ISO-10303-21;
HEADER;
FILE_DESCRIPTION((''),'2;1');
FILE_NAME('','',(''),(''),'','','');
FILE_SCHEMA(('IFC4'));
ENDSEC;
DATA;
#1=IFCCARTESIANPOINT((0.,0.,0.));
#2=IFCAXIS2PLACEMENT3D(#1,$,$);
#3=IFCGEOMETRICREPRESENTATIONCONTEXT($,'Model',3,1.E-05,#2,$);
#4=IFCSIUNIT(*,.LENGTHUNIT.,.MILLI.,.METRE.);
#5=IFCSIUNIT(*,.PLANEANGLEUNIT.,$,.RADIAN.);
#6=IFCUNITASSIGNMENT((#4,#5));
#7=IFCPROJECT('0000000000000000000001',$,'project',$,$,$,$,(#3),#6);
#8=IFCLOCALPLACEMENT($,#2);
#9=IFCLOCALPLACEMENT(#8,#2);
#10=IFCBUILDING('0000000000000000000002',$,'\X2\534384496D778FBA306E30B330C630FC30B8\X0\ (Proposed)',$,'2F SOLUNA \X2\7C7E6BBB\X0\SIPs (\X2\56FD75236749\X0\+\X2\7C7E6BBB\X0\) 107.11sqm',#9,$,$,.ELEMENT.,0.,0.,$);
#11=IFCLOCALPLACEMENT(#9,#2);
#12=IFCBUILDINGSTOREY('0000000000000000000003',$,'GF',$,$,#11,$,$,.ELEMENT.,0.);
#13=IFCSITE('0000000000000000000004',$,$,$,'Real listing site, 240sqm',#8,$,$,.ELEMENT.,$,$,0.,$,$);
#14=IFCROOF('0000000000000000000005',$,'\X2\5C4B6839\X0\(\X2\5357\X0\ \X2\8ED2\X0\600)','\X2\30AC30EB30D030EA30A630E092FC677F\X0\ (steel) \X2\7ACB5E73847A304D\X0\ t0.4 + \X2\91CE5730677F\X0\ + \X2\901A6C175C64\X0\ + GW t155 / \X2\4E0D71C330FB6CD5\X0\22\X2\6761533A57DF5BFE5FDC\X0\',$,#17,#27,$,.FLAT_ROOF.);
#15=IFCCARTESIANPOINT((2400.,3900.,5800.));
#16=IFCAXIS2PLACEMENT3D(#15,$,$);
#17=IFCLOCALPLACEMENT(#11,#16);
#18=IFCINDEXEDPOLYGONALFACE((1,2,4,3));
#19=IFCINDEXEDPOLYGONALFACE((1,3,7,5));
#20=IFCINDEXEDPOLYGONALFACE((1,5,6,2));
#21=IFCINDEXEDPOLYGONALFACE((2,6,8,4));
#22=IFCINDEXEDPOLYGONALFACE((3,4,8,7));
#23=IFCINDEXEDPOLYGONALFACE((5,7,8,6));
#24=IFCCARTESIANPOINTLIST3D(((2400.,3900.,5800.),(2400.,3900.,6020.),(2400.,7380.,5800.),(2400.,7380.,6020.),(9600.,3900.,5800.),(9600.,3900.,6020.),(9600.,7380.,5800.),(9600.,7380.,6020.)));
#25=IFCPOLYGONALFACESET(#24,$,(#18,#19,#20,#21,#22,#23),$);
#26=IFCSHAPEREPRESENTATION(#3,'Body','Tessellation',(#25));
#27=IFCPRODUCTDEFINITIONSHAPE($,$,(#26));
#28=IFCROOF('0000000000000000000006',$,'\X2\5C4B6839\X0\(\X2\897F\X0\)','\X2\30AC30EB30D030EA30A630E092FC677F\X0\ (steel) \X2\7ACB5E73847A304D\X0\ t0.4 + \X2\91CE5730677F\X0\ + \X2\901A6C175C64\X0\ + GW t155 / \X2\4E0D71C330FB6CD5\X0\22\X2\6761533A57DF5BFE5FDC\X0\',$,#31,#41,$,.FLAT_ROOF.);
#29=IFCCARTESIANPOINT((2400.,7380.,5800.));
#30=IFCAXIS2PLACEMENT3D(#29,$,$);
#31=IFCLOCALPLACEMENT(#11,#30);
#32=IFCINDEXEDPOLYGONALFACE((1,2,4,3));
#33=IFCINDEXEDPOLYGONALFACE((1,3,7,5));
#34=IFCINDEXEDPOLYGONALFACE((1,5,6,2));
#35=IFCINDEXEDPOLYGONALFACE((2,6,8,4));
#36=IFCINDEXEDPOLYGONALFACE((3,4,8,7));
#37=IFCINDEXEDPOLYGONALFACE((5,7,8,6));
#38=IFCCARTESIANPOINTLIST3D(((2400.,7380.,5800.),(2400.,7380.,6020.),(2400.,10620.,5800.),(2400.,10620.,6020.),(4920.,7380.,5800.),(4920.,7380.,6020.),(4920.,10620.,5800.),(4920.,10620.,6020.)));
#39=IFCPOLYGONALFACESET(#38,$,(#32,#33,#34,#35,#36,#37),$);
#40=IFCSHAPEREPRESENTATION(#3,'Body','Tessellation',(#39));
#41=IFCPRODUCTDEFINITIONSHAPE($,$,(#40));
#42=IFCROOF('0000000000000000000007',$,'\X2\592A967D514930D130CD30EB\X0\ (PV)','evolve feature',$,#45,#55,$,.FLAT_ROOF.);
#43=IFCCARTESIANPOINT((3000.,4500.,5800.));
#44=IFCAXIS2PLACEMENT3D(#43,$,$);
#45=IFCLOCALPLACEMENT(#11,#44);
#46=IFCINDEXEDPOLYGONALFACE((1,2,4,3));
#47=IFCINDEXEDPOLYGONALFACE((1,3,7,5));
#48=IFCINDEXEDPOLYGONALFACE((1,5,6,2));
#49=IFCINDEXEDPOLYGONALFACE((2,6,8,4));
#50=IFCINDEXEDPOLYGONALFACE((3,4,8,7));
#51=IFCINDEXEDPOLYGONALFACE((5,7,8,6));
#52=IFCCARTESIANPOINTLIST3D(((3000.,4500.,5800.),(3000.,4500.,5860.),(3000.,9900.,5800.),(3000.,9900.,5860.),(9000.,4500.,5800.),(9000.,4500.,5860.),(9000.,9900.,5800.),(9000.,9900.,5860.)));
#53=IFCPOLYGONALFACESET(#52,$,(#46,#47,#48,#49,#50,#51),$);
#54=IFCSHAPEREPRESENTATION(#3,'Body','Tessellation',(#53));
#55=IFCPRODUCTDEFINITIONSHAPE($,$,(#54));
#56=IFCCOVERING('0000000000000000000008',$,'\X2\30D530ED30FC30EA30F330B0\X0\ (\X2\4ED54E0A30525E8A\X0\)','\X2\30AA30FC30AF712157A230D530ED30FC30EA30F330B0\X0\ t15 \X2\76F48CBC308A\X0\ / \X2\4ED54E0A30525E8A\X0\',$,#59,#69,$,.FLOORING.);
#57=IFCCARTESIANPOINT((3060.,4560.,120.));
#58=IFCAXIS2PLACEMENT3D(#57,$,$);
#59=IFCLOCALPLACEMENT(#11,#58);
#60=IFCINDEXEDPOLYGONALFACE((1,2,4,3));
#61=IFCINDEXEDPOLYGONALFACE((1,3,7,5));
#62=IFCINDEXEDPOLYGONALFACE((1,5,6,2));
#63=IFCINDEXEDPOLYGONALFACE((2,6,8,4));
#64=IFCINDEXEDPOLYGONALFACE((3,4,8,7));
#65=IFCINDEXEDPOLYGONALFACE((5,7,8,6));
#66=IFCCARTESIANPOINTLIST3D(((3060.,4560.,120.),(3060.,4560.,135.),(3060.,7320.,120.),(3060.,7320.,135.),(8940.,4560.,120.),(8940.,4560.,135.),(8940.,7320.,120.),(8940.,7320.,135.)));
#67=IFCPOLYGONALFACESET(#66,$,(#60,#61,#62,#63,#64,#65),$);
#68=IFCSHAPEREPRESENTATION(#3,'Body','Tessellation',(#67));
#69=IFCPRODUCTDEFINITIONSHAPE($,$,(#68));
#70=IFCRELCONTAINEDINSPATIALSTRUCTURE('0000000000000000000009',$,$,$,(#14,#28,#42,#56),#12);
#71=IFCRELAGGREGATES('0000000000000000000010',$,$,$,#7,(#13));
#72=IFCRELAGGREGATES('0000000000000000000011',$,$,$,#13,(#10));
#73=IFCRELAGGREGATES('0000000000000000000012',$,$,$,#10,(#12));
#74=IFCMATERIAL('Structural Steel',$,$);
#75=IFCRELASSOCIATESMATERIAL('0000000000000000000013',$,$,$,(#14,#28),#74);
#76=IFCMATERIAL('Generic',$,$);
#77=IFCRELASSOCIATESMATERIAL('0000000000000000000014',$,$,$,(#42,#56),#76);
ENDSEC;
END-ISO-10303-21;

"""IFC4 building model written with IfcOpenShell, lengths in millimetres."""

from ifc_helpers import new_model, si_unit, frame, frame_2d, origin, place, context, project, spatial, rectangle, extrude, material, element, save


model = new_model("IFC4")

# Units and contexts
model_context = context("Model", 3, precision=1e-05, world=origin())
ifc_project = project(units=[si_unit("LENGTHUNIT", "METRE", prefix="MILLI"), si_unit("PLANEANGLEUNIT", "RADIAN")], contexts=[model_context])

# Site, building, storey
site_placement = place(None, origin())
site = spatial("IfcSite", under=ifc_project, at=site_placement, ObjectType="Real listing site, 240sqm", CompositionType="ELEMENT", RefElevation=0.0)
building_placement = place(site_placement, origin())
building = spatial("IfcBuilding", under=site, at=building_placement, Name="千葉海辺のコテージ (Proposed)", ObjectType="2F SOLUNA 籾殻SIPs (国産杉+籾殻) 107.11sqm", CompositionType="ELEMENT", ElevationOfRefHeight=0.0, ElevationOfTerrain=0.0)
storey_placement = place(building_placement, origin())
storey = spatial("IfcBuildingStorey", under=building, at=storey_placement, Name="GF", CompositionType="ELEMENT", Elevation=0.0)

# Shared definitions
ifc_material_1 = material(Name="Generic")

# Roofs
ifc_material_2 = material(Name="Structural Steel")
roof_1_placement = place(storey_placement, frame((2400.0, 3900.0, 5800.0)))
element("IfcRoof", 1, at=roof_1_placement, inside=storey, material=ifc_material_2, Name="屋根(南 軒600)", Description="ガルバリウム鋼板 (steel) 立平葺き t0.4 + 野地板 + 通気層 + GW t155 / 不燃・法22条区域対応", PredefinedType="FLAT_ROOF", context=model_context, shape_type="SweptSolid", body=[
    extrude(rectangle(XDim=7200.0, YDim=3480.0, at=frame_2d((3600.0, 1740.0))), frame((2400.0, 3900.0, 5800.0)), (0.0, 0.0, 1.0), 220.0),
])
roof_2_placement = place(storey_placement, frame((2400.0, 7380.0, 5800.0)))
element("IfcRoof", 2, at=roof_2_placement, inside=storey, material=ifc_material_2, Name="屋根(西)", Description="ガルバリウム鋼板 (steel) 立平葺き t0.4 + 野地板 + 通気層 + GW t155 / 不燃・法22条区域対応", PredefinedType="FLAT_ROOF", context=model_context, shape_type="SweptSolid", body=[
    extrude(rectangle(XDim=2520.0, YDim=3240.0, at=frame_2d((1260.0, 1620.0))), frame((2400.0, 7380.0, 5800.0)), (0.0, 0.0, 1.0), 220.0),
])
roof_3_placement = place(storey_placement, frame((3000.0, 4500.0, 5800.0)))
element("IfcRoof", 3, at=roof_3_placement, inside=storey, material=ifc_material_1, Name="太陽光パネル (PV)", Description="evolve feature", PredefinedType="FLAT_ROOF", context=model_context, shape_type="SweptSolid", body=[
    extrude(rectangle(XDim=6000.0, YDim=5400.0, at=frame_2d((3000.0, 2700.0))), frame((3000.0, 4500.0, 5800.0)), (0.0, 0.0, 1.0), 60.0),
])

# Covering
covering_placement = place(storey_placement, frame((3060.0, 4560.0, 120.0)))
element("IfcCovering", 4, at=covering_placement, inside=storey, material=ifc_material_1, Name="フローリング (仕上げ床)", Description="オーク無垢フローリング t15 直貼り / 仕上げ床", PredefinedType="FLOORING", context=model_context, shape_type="SweptSolid", body=[
    extrude(rectangle(XDim=5880.0, YDim=2760.0, at=frame_2d((2940.0, 1380.0))), frame((3060.0, 4560.0, 120.0)), (0.0, 0.0, 1.0), 15.0),
])

save(model, "model.ifc")
